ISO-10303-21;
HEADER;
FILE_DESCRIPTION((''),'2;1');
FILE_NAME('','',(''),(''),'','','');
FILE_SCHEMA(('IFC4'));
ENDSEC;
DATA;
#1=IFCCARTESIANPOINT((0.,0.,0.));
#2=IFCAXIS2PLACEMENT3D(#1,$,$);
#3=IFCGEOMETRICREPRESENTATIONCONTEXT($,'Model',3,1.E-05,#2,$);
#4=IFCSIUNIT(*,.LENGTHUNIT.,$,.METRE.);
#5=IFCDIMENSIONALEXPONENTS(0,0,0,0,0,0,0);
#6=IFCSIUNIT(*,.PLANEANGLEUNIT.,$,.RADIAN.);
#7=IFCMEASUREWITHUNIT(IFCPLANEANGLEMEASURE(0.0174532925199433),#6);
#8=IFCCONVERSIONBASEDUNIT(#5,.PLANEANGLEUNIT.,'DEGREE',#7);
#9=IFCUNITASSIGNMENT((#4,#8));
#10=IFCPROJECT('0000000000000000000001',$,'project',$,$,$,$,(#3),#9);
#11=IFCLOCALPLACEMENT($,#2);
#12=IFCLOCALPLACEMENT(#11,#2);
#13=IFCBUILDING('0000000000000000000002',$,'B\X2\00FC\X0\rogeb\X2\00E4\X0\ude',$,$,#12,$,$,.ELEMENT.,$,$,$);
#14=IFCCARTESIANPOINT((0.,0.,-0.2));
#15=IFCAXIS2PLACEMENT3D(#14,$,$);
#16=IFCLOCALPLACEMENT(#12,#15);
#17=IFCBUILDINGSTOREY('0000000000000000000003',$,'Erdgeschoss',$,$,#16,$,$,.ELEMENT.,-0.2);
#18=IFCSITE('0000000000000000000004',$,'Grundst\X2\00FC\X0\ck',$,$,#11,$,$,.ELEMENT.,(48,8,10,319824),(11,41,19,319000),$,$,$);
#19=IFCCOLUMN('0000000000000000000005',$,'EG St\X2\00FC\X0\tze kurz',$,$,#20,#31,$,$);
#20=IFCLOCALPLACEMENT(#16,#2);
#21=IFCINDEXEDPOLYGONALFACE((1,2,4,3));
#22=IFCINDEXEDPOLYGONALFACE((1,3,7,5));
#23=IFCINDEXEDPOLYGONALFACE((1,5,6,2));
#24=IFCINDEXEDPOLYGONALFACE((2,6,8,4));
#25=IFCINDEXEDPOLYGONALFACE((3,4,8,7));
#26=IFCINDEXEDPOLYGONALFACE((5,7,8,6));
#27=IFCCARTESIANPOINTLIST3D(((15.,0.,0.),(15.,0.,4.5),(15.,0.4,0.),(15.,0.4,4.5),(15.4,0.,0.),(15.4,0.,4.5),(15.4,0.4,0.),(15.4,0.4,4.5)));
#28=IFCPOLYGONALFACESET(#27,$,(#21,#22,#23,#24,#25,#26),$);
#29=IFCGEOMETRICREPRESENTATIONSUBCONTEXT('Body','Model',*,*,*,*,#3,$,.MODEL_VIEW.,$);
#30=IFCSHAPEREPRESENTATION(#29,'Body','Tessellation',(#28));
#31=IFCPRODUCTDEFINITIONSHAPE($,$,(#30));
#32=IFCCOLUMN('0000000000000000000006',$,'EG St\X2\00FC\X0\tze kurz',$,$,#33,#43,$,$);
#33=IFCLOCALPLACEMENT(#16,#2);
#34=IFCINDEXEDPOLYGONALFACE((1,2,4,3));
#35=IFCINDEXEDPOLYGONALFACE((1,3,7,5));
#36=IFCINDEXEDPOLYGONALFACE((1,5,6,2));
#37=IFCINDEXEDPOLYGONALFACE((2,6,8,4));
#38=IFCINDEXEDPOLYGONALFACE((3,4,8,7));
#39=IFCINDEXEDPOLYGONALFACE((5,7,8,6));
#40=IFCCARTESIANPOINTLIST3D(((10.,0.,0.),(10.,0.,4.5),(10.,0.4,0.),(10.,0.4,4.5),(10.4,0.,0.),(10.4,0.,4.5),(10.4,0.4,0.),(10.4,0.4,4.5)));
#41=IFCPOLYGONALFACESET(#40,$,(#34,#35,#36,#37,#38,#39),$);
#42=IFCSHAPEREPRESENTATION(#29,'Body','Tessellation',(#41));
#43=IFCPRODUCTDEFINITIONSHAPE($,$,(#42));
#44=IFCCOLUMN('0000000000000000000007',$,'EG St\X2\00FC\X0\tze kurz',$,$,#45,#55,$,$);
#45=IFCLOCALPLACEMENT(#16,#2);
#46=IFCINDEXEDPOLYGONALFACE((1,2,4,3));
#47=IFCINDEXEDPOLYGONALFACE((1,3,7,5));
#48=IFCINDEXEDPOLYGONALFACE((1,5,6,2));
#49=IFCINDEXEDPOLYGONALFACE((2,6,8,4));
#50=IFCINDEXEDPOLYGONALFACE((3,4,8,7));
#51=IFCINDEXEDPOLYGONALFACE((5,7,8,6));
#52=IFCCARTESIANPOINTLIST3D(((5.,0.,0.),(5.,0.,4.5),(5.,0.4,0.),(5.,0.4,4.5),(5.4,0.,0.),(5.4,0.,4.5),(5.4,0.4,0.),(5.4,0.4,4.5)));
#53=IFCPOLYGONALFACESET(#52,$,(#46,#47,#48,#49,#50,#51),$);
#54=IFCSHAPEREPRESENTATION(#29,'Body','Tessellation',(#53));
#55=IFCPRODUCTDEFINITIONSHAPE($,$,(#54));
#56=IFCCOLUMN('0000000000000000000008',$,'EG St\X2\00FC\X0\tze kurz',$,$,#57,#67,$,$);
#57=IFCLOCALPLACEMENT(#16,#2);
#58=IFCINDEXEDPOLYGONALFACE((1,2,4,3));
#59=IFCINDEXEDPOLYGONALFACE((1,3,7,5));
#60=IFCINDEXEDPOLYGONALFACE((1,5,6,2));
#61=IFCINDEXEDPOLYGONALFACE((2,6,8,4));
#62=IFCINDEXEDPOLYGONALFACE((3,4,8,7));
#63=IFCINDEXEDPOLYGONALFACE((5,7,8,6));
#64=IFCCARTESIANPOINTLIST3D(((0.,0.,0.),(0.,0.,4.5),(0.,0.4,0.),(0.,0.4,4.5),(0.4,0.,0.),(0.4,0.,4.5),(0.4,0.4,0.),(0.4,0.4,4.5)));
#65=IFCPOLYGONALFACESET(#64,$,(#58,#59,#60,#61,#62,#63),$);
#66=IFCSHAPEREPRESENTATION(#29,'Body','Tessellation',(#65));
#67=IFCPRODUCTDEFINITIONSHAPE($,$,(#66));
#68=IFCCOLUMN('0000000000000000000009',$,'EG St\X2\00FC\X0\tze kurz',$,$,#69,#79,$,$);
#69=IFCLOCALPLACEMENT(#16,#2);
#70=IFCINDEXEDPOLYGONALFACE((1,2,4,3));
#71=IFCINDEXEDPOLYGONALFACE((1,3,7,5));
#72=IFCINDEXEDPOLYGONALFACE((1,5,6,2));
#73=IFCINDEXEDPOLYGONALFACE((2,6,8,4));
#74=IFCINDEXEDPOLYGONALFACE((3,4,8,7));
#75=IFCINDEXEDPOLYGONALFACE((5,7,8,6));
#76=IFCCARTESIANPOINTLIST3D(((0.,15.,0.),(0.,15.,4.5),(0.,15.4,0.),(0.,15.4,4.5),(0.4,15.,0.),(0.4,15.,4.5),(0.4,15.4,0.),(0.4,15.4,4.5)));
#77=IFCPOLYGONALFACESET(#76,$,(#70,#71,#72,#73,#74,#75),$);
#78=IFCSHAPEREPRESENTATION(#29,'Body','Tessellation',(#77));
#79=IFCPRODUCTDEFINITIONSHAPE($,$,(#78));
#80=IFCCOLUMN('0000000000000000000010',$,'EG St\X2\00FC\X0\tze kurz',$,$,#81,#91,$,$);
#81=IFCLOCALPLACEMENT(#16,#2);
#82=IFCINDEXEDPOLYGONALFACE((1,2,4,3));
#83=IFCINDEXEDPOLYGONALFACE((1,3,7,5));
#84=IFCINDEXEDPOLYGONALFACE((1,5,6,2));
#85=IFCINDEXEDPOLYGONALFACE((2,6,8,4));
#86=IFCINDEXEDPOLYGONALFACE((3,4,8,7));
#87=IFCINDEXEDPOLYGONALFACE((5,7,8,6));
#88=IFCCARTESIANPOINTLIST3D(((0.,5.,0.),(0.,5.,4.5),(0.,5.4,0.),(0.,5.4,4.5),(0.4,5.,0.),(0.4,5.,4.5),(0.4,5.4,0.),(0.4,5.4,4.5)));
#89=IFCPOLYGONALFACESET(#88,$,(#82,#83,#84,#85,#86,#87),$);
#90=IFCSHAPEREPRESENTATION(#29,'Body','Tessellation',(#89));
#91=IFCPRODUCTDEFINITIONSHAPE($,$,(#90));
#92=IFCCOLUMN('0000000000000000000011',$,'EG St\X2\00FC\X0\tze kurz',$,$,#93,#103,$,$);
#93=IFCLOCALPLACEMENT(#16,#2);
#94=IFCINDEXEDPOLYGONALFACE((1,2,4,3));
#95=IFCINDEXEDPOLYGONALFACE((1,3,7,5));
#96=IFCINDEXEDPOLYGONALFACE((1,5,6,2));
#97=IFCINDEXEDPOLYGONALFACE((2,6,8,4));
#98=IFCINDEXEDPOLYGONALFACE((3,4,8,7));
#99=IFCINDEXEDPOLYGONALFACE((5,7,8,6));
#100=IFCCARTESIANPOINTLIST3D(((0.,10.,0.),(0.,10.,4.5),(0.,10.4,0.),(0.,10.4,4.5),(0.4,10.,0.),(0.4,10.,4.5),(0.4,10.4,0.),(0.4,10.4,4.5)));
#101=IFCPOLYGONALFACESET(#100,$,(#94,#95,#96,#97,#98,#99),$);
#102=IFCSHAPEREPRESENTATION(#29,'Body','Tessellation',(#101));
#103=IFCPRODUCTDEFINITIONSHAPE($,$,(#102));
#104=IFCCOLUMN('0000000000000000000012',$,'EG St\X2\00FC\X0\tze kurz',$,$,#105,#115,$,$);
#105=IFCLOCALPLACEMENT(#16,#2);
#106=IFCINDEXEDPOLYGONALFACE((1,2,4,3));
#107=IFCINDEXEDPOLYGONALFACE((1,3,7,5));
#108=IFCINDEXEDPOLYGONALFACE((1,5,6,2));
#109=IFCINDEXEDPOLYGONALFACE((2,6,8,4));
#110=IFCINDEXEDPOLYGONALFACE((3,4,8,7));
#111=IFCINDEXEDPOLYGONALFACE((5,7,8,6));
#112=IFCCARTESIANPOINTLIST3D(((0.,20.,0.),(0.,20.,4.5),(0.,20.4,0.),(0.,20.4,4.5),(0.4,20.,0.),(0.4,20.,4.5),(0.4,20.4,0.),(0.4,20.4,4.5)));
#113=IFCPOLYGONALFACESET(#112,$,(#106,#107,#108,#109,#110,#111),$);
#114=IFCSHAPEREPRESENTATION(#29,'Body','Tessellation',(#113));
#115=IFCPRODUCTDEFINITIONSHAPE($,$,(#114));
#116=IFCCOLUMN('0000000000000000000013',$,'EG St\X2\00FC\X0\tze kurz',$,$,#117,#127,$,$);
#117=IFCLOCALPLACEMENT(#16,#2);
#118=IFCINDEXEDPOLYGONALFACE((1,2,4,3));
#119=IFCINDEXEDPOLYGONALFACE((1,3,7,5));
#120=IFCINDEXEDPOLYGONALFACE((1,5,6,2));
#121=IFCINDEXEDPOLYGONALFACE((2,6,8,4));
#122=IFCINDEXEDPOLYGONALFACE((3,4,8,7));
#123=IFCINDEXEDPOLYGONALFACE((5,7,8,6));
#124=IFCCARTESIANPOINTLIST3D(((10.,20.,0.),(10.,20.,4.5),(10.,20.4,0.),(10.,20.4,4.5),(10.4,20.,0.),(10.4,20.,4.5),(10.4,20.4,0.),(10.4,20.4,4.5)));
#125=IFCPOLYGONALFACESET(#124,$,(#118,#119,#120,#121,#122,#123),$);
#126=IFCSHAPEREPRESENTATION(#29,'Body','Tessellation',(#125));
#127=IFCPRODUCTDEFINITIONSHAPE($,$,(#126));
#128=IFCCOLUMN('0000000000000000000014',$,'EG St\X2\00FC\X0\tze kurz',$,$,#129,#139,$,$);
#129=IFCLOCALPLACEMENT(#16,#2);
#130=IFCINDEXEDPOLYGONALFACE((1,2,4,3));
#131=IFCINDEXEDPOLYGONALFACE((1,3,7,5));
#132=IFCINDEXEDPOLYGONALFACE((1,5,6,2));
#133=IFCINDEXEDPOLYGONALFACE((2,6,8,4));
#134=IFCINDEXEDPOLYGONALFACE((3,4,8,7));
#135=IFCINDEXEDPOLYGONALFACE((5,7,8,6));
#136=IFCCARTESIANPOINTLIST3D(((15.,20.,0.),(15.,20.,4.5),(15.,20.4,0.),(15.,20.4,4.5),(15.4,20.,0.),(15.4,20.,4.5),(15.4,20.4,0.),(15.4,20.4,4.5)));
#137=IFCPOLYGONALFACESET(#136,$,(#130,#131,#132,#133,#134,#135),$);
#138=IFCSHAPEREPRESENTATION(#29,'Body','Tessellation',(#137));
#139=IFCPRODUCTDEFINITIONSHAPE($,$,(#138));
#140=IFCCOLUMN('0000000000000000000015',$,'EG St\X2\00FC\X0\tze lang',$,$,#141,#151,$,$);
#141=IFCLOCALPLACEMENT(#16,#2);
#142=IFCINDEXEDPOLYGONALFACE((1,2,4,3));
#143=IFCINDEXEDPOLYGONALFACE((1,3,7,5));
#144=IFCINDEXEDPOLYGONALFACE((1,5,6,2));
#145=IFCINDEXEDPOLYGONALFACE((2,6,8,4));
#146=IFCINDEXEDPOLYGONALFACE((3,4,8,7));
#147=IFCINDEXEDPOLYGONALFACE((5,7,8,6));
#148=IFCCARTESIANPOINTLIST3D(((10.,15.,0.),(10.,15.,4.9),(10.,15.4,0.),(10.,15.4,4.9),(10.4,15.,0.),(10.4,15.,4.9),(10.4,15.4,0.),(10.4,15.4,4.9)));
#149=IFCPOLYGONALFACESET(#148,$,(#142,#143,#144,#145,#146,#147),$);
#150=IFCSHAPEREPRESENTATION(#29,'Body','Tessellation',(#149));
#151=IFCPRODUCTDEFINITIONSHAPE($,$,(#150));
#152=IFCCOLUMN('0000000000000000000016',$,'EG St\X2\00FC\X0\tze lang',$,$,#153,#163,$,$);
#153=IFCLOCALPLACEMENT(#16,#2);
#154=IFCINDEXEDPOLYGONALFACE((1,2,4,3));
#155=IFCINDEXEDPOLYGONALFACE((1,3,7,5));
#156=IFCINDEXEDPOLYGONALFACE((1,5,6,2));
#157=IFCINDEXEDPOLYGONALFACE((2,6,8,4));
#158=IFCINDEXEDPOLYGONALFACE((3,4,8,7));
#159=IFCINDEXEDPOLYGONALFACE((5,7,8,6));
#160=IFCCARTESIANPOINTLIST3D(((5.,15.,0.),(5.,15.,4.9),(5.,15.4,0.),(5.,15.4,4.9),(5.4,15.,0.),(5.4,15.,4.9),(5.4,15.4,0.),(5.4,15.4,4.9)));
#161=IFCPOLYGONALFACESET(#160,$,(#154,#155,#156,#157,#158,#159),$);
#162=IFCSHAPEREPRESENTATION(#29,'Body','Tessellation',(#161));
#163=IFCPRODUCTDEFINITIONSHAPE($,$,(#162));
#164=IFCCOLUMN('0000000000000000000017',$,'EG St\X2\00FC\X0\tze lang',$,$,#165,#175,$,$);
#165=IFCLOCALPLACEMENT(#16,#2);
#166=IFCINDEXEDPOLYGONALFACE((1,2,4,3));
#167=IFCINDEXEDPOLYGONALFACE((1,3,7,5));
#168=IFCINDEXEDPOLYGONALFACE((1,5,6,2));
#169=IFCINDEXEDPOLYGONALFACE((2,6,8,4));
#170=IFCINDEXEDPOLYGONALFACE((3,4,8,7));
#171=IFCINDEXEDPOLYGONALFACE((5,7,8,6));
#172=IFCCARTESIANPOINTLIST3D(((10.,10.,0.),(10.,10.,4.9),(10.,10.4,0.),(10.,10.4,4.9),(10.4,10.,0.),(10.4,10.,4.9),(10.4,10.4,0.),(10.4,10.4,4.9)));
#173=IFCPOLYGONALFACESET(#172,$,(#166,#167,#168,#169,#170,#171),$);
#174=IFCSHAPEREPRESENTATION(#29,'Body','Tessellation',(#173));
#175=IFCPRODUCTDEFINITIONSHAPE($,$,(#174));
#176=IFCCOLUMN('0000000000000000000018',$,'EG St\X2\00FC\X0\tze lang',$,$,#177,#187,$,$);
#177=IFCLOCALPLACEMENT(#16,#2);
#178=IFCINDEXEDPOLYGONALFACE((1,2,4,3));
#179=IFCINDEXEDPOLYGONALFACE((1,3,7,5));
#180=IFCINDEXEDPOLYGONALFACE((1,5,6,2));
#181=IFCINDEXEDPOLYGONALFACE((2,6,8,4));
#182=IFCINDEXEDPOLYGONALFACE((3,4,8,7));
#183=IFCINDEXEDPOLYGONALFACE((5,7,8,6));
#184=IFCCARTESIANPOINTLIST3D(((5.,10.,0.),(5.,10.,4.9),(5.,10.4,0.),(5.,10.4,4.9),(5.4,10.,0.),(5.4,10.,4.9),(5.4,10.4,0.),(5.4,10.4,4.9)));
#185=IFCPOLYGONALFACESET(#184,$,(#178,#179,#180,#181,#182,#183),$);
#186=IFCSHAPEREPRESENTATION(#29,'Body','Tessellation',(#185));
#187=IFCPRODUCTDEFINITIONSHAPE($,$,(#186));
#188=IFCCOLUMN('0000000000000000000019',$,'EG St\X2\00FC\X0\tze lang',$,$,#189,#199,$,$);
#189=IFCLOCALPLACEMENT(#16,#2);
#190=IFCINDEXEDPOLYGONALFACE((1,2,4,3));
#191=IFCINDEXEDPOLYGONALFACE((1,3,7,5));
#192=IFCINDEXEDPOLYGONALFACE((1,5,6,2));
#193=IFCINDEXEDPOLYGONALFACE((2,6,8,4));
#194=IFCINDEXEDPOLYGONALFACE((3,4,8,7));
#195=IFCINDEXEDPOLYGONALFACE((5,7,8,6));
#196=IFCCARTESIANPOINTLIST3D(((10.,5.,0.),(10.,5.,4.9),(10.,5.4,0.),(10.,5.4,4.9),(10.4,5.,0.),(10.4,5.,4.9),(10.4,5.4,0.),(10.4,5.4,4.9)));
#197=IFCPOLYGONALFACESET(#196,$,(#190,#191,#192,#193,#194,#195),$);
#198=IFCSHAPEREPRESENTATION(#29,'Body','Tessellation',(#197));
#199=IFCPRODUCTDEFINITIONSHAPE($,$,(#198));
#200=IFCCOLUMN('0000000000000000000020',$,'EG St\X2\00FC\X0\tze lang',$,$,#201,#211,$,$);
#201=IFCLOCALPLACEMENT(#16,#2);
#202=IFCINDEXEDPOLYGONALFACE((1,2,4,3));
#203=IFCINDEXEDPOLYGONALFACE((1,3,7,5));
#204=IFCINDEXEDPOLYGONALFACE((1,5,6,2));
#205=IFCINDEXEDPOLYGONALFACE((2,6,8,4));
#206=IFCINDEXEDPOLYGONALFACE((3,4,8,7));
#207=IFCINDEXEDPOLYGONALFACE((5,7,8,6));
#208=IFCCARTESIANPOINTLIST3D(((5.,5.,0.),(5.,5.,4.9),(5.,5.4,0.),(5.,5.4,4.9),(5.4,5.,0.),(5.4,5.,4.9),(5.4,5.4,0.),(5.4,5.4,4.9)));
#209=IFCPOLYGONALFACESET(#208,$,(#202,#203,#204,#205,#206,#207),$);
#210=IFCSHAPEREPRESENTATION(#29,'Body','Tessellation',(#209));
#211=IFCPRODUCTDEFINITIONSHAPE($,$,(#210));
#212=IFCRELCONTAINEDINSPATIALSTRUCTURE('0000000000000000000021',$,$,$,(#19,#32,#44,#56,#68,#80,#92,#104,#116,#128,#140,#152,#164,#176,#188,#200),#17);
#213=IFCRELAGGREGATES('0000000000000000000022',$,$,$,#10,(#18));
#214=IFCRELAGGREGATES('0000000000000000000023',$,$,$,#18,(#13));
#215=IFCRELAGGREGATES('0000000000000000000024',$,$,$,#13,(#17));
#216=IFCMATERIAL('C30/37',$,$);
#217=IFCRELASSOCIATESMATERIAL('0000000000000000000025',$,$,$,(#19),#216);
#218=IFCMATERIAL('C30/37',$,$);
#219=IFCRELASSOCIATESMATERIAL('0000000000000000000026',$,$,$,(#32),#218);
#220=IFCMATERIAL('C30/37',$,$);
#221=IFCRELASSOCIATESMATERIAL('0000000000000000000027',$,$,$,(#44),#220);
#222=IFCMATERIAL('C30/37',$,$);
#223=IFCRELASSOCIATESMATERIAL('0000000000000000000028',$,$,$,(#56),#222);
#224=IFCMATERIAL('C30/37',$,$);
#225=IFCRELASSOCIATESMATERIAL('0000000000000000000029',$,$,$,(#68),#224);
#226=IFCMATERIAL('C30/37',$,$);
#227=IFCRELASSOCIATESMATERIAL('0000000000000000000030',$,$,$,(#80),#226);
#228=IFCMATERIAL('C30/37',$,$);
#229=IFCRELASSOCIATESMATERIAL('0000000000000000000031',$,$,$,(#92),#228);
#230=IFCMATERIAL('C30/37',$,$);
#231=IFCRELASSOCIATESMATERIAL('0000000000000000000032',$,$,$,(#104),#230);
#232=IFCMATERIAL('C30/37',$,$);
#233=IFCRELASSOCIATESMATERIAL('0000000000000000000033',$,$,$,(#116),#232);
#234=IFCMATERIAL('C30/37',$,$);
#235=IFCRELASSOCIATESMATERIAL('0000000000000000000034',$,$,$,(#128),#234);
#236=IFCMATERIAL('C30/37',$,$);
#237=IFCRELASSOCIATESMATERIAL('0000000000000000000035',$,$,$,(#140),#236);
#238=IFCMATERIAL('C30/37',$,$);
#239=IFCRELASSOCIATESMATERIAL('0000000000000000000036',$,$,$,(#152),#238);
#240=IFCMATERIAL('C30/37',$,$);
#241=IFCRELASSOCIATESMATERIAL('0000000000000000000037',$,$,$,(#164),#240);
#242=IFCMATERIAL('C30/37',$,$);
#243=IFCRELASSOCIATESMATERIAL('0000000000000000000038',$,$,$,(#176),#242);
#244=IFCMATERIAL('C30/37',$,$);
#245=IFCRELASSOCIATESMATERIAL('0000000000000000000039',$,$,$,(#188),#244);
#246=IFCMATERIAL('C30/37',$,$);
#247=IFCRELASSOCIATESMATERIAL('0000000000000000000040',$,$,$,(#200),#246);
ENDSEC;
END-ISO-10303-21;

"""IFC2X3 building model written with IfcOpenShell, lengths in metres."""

from ifc_helpers import new_model, entity, si_unit, converted_unit, frame, frame_2d, origin, origin_with_axes, place, context, subcontext, project, spatial, rectangle, extrude, material, element, save


model = new_model("IFC2X3")

# Units and contexts
model_context = context("Model", 3, precision=1e-05, world=origin())
body_context = subcontext(model_context, "Body", "Model", "MODEL_VIEW")
ifc_project = project(units=[si_unit("LENGTHUNIT", "METRE"), converted_unit("PLANEANGLEUNIT", "DEGREE", entity("IfcPlaneAngleMeasure", 0.0174532925199433), si_unit("PLANEANGLEUNIT", "RADIAN"), dimensions=[0, 0, 0, 0, 0, 0, 0])], contexts=[model_context])

# Site, building, storey
site_placement = place(None, origin())
site = spatial("IfcSite", under=ifc_project, at=site_placement, Name="Grundstück", CompositionType="ELEMENT", RefLatitude=(48, 8, 10, 319824), RefLongitude=(11, 41, 19, 319000))
building_placement = place(site_placement, origin())
building = spatial("IfcBuilding", under=site, at=building_placement, Name="Bürogebäude", CompositionType="ELEMENT")
storey_placement = place(building_placement, frame((0.0, 0.0, -0.2)))
storey = spatial("IfcBuildingStorey", under=building, at=storey_placement, Name="Erdgeschoss", CompositionType="ELEMENT", Elevation=-0.2)

# Columns
ifc_material_1 = material(Name="C30/37")
column_1_placement = place(storey_placement, frame((15.0, 0.0, 0.0)))
element("IfcColumn", 1, at=column_1_placement, inside=storey, material=ifc_material_1, Name="EG Stütze kurz", context=body_context, shape_type="SweptSolid", body=[
    extrude(rectangle(XDim=0.4, YDim=0.4, at=frame_2d((0.2, 0.2), x_axis=(1.0, 0.0))), origin_with_axes(), (0.0, 0.0, 1.0), 4.5),
])
ifc_material_2 = material(Name="C30/37")
column_2_placement = place(storey_placement, frame((10.0, 0.0, 0.0)))
element("IfcColumn", 2, at=column_2_placement, inside=storey, material=ifc_material_2, Name="EG Stütze kurz", context=body_context, shape_type="SweptSolid", body=[
    extrude(rectangle(XDim=0.4, YDim=0.4, at=frame_2d((0.2, 0.2), x_axis=(1.0, 0.0))), origin_with_axes(), (0.0, 0.0, 1.0), 4.5),
])
ifc_material_3 = material(Name="C30/37")
column_3_placement = place(storey_placement, frame((5.0, 0.0, 0.0)))
element("IfcColumn", 3, at=column_3_placement, inside=storey, material=ifc_material_3, Name="EG Stütze kurz", context=body_context, shape_type="SweptSolid", body=[
    extrude(rectangle(XDim=0.4, YDim=0.4, at=frame_2d((0.2, 0.2), x_axis=(1.0, 0.0))), origin_with_axes(), (0.0, 0.0, 1.0), 4.5),
])
ifc_material_4 = material(Name="C30/37")
column_4_placement = place(storey_placement, origin())
element("IfcColumn", 4, at=column_4_placement, inside=storey, material=ifc_material_4, Name="EG Stütze kurz", context=body_context, shape_type="SweptSolid", body=[
    extrude(rectangle(XDim=0.4, YDim=0.4, at=frame_2d((0.2, 0.2), x_axis=(1.0, 0.0))), origin_with_axes(), (0.0, 0.0, 1.0), 4.5),
])
ifc_material_5 = material(Name="C30/37")
column_5_placement = place(storey_placement, frame((0.0, 15.0, 0.0)))
element("IfcColumn", 5, at=column_5_placement, inside=storey, material=ifc_material_5, Name="EG Stütze kurz", context=body_context, shape_type="SweptSolid", body=[
    extrude(rectangle(XDim=0.4, YDim=0.4, at=frame_2d((0.2, 0.2), x_axis=(1.0, 0.0))), origin_with_axes(), (0.0, 0.0, 1.0), 4.5),
])
ifc_material_6 = material(Name="C30/37")
column_6_placement = place(storey_placement, frame((0.0, 5.0, 0.0)))
element("IfcColumn", 6, at=column_6_placement, inside=storey, material=ifc_material_6, Name="EG Stütze kurz", context=body_context, shape_type="SweptSolid", body=[
    extrude(rectangle(XDim=0.4, YDim=0.4, at=frame_2d((0.2, 0.2), x_axis=(1.0, 0.0))), origin_with_axes(), (0.0, 0.0, 1.0), 4.5),
])
ifc_material_7 = material(Name="C30/37")
column_7_placement = place(storey_placement, frame((0.0, 10.0, 0.0)))
element("IfcColumn", 7, at=column_7_placement, inside=storey, material=ifc_material_7, Name="EG Stütze kurz", context=body_context, shape_type="SweptSolid", body=[
    extrude(rectangle(XDim=0.4, YDim=0.4, at=frame_2d((0.2, 0.2), x_axis=(1.0, 0.0))), origin_with_axes(), (0.0, 0.0, 1.0), 4.5),
])
ifc_material_8 = material(Name="C30/37")
column_8_placement = place(storey_placement, frame((0.0, 20.0, 0.0)))
element("IfcColumn", 8, at=column_8_placement, inside=storey, material=ifc_material_8, Name="EG Stütze kurz", context=body_context, shape_type="SweptSolid", body=[
    extrude(rectangle(XDim=0.4, YDim=0.4, at=frame_2d((0.2, 0.2), x_axis=(1.0, 0.0))), origin_with_axes(), (0.0, 0.0, 1.0), 4.5),
])
ifc_material_9 = material(Name="C30/37")
column_9_placement = place(storey_placement, frame((10.0, 20.0, 0.0)))
element("IfcColumn", 9, at=column_9_placement, inside=storey, material=ifc_material_9, Name="EG Stütze kurz", context=body_context, shape_type="SweptSolid", body=[
    extrude(rectangle(XDim=0.4, YDim=0.4, at=frame_2d((0.2, 0.2), x_axis=(1.0, 0.0))), origin_with_axes(), (0.0, 0.0, 1.0), 4.5),
])
ifc_material_10 = material(Name="C30/37")
column_10_placement = place(storey_placement, frame((15.0, 20.0, 0.0)))
element("IfcColumn", 10, at=column_10_placement, inside=storey, material=ifc_material_10, Name="EG Stütze kurz", context=body_context, shape_type="SweptSolid", body=[
    extrude(rectangle(XDim=0.4, YDim=0.4, at=frame_2d((0.2, 0.2), x_axis=(1.0, 0.0))), origin_with_axes(), (0.0, 0.0, 1.0), 4.5),
])
ifc_material_11 = material(Name="C30/37")
column_11_placement = place(storey_placement, frame((10.0, 15.0, 0.0)))
element("IfcColumn", 11, at=column_11_placement, inside=storey, material=ifc_material_11, Name="EG Stütze lang", context=body_context, shape_type="SweptSolid", body=[
    extrude(rectangle(XDim=0.4, YDim=0.4, at=frame_2d((0.2, 0.2), x_axis=(1.0, 0.0))), origin_with_axes(), (0.0, 0.0, 1.0), 4.9),
])
ifc_material_12 = material(Name="C30/37")
column_12_placement = place(storey_placement, frame((5.0, 15.0, 0.0)))
element("IfcColumn", 12, at=column_12_placement, inside=storey, material=ifc_material_12, Name="EG Stütze lang", context=body_context, shape_type="SweptSolid", body=[
    extrude(rectangle(XDim=0.4, YDim=0.4, at=frame_2d((0.2, 0.2), x_axis=(1.0, 0.0))), origin_with_axes(), (0.0, 0.0, 1.0), 4.9),
])
ifc_material_13 = material(Name="C30/37")
column_13_placement = place(storey_placement, frame((10.0, 10.0, 0.0)))
element("IfcColumn", 13, at=column_13_placement, inside=storey, material=ifc_material_13, Name="EG Stütze lang", context=body_context, shape_type="SweptSolid", body=[
    extrude(rectangle(XDim=0.4, YDim=0.4, at=frame_2d((0.2, 0.2), x_axis=(1.0, 0.0))), origin_with_axes(), (0.0, 0.0, 1.0), 4.9),
])
ifc_material_14 = material(Name="C30/37")
column_14_placement = place(storey_placement, frame((5.0, 10.0, 0.0)))
element("IfcColumn", 14, at=column_14_placement, inside=storey, material=ifc_material_14, Name="EG Stütze lang", context=body_context, shape_type="SweptSolid", body=[
    extrude(rectangle(XDim=0.4, YDim=0.4, at=frame_2d((0.2, 0.2), x_axis=(1.0, 0.0))), origin_with_axes(), (0.0, 0.0, 1.0), 4.9),
])
ifc_material_15 = material(Name="C30/37")
column_15_placement = place(storey_placement, frame((10.0, 5.0, 0.0)))
element("IfcColumn", 15, at=column_15_placement, inside=storey, material=ifc_material_15, Name="EG Stütze lang", context=body_context, shape_type="SweptSolid", body=[
    extrude(rectangle(XDim=0.4, YDim=0.4, at=frame_2d((0.2, 0.2), x_axis=(1.0, 0.0))), origin_with_axes(), (0.0, 0.0, 1.0), 4.9),
])
ifc_material_16 = material(Name="C30/37")
column_16_placement = place(storey_placement, frame((5.0, 5.0, 0.0)))
element("IfcColumn", 16, at=column_16_placement, inside=storey, material=ifc_material_16, Name="EG Stütze lang", context=body_context, shape_type="SweptSolid", body=[
    extrude(rectangle(XDim=0.4, YDim=0.4, at=frame_2d((0.2, 0.2), x_axis=(1.0, 0.0))), origin_with_axes(), (0.0, 0.0, 1.0), 4.9),
])

save(model, "model.ifc")
